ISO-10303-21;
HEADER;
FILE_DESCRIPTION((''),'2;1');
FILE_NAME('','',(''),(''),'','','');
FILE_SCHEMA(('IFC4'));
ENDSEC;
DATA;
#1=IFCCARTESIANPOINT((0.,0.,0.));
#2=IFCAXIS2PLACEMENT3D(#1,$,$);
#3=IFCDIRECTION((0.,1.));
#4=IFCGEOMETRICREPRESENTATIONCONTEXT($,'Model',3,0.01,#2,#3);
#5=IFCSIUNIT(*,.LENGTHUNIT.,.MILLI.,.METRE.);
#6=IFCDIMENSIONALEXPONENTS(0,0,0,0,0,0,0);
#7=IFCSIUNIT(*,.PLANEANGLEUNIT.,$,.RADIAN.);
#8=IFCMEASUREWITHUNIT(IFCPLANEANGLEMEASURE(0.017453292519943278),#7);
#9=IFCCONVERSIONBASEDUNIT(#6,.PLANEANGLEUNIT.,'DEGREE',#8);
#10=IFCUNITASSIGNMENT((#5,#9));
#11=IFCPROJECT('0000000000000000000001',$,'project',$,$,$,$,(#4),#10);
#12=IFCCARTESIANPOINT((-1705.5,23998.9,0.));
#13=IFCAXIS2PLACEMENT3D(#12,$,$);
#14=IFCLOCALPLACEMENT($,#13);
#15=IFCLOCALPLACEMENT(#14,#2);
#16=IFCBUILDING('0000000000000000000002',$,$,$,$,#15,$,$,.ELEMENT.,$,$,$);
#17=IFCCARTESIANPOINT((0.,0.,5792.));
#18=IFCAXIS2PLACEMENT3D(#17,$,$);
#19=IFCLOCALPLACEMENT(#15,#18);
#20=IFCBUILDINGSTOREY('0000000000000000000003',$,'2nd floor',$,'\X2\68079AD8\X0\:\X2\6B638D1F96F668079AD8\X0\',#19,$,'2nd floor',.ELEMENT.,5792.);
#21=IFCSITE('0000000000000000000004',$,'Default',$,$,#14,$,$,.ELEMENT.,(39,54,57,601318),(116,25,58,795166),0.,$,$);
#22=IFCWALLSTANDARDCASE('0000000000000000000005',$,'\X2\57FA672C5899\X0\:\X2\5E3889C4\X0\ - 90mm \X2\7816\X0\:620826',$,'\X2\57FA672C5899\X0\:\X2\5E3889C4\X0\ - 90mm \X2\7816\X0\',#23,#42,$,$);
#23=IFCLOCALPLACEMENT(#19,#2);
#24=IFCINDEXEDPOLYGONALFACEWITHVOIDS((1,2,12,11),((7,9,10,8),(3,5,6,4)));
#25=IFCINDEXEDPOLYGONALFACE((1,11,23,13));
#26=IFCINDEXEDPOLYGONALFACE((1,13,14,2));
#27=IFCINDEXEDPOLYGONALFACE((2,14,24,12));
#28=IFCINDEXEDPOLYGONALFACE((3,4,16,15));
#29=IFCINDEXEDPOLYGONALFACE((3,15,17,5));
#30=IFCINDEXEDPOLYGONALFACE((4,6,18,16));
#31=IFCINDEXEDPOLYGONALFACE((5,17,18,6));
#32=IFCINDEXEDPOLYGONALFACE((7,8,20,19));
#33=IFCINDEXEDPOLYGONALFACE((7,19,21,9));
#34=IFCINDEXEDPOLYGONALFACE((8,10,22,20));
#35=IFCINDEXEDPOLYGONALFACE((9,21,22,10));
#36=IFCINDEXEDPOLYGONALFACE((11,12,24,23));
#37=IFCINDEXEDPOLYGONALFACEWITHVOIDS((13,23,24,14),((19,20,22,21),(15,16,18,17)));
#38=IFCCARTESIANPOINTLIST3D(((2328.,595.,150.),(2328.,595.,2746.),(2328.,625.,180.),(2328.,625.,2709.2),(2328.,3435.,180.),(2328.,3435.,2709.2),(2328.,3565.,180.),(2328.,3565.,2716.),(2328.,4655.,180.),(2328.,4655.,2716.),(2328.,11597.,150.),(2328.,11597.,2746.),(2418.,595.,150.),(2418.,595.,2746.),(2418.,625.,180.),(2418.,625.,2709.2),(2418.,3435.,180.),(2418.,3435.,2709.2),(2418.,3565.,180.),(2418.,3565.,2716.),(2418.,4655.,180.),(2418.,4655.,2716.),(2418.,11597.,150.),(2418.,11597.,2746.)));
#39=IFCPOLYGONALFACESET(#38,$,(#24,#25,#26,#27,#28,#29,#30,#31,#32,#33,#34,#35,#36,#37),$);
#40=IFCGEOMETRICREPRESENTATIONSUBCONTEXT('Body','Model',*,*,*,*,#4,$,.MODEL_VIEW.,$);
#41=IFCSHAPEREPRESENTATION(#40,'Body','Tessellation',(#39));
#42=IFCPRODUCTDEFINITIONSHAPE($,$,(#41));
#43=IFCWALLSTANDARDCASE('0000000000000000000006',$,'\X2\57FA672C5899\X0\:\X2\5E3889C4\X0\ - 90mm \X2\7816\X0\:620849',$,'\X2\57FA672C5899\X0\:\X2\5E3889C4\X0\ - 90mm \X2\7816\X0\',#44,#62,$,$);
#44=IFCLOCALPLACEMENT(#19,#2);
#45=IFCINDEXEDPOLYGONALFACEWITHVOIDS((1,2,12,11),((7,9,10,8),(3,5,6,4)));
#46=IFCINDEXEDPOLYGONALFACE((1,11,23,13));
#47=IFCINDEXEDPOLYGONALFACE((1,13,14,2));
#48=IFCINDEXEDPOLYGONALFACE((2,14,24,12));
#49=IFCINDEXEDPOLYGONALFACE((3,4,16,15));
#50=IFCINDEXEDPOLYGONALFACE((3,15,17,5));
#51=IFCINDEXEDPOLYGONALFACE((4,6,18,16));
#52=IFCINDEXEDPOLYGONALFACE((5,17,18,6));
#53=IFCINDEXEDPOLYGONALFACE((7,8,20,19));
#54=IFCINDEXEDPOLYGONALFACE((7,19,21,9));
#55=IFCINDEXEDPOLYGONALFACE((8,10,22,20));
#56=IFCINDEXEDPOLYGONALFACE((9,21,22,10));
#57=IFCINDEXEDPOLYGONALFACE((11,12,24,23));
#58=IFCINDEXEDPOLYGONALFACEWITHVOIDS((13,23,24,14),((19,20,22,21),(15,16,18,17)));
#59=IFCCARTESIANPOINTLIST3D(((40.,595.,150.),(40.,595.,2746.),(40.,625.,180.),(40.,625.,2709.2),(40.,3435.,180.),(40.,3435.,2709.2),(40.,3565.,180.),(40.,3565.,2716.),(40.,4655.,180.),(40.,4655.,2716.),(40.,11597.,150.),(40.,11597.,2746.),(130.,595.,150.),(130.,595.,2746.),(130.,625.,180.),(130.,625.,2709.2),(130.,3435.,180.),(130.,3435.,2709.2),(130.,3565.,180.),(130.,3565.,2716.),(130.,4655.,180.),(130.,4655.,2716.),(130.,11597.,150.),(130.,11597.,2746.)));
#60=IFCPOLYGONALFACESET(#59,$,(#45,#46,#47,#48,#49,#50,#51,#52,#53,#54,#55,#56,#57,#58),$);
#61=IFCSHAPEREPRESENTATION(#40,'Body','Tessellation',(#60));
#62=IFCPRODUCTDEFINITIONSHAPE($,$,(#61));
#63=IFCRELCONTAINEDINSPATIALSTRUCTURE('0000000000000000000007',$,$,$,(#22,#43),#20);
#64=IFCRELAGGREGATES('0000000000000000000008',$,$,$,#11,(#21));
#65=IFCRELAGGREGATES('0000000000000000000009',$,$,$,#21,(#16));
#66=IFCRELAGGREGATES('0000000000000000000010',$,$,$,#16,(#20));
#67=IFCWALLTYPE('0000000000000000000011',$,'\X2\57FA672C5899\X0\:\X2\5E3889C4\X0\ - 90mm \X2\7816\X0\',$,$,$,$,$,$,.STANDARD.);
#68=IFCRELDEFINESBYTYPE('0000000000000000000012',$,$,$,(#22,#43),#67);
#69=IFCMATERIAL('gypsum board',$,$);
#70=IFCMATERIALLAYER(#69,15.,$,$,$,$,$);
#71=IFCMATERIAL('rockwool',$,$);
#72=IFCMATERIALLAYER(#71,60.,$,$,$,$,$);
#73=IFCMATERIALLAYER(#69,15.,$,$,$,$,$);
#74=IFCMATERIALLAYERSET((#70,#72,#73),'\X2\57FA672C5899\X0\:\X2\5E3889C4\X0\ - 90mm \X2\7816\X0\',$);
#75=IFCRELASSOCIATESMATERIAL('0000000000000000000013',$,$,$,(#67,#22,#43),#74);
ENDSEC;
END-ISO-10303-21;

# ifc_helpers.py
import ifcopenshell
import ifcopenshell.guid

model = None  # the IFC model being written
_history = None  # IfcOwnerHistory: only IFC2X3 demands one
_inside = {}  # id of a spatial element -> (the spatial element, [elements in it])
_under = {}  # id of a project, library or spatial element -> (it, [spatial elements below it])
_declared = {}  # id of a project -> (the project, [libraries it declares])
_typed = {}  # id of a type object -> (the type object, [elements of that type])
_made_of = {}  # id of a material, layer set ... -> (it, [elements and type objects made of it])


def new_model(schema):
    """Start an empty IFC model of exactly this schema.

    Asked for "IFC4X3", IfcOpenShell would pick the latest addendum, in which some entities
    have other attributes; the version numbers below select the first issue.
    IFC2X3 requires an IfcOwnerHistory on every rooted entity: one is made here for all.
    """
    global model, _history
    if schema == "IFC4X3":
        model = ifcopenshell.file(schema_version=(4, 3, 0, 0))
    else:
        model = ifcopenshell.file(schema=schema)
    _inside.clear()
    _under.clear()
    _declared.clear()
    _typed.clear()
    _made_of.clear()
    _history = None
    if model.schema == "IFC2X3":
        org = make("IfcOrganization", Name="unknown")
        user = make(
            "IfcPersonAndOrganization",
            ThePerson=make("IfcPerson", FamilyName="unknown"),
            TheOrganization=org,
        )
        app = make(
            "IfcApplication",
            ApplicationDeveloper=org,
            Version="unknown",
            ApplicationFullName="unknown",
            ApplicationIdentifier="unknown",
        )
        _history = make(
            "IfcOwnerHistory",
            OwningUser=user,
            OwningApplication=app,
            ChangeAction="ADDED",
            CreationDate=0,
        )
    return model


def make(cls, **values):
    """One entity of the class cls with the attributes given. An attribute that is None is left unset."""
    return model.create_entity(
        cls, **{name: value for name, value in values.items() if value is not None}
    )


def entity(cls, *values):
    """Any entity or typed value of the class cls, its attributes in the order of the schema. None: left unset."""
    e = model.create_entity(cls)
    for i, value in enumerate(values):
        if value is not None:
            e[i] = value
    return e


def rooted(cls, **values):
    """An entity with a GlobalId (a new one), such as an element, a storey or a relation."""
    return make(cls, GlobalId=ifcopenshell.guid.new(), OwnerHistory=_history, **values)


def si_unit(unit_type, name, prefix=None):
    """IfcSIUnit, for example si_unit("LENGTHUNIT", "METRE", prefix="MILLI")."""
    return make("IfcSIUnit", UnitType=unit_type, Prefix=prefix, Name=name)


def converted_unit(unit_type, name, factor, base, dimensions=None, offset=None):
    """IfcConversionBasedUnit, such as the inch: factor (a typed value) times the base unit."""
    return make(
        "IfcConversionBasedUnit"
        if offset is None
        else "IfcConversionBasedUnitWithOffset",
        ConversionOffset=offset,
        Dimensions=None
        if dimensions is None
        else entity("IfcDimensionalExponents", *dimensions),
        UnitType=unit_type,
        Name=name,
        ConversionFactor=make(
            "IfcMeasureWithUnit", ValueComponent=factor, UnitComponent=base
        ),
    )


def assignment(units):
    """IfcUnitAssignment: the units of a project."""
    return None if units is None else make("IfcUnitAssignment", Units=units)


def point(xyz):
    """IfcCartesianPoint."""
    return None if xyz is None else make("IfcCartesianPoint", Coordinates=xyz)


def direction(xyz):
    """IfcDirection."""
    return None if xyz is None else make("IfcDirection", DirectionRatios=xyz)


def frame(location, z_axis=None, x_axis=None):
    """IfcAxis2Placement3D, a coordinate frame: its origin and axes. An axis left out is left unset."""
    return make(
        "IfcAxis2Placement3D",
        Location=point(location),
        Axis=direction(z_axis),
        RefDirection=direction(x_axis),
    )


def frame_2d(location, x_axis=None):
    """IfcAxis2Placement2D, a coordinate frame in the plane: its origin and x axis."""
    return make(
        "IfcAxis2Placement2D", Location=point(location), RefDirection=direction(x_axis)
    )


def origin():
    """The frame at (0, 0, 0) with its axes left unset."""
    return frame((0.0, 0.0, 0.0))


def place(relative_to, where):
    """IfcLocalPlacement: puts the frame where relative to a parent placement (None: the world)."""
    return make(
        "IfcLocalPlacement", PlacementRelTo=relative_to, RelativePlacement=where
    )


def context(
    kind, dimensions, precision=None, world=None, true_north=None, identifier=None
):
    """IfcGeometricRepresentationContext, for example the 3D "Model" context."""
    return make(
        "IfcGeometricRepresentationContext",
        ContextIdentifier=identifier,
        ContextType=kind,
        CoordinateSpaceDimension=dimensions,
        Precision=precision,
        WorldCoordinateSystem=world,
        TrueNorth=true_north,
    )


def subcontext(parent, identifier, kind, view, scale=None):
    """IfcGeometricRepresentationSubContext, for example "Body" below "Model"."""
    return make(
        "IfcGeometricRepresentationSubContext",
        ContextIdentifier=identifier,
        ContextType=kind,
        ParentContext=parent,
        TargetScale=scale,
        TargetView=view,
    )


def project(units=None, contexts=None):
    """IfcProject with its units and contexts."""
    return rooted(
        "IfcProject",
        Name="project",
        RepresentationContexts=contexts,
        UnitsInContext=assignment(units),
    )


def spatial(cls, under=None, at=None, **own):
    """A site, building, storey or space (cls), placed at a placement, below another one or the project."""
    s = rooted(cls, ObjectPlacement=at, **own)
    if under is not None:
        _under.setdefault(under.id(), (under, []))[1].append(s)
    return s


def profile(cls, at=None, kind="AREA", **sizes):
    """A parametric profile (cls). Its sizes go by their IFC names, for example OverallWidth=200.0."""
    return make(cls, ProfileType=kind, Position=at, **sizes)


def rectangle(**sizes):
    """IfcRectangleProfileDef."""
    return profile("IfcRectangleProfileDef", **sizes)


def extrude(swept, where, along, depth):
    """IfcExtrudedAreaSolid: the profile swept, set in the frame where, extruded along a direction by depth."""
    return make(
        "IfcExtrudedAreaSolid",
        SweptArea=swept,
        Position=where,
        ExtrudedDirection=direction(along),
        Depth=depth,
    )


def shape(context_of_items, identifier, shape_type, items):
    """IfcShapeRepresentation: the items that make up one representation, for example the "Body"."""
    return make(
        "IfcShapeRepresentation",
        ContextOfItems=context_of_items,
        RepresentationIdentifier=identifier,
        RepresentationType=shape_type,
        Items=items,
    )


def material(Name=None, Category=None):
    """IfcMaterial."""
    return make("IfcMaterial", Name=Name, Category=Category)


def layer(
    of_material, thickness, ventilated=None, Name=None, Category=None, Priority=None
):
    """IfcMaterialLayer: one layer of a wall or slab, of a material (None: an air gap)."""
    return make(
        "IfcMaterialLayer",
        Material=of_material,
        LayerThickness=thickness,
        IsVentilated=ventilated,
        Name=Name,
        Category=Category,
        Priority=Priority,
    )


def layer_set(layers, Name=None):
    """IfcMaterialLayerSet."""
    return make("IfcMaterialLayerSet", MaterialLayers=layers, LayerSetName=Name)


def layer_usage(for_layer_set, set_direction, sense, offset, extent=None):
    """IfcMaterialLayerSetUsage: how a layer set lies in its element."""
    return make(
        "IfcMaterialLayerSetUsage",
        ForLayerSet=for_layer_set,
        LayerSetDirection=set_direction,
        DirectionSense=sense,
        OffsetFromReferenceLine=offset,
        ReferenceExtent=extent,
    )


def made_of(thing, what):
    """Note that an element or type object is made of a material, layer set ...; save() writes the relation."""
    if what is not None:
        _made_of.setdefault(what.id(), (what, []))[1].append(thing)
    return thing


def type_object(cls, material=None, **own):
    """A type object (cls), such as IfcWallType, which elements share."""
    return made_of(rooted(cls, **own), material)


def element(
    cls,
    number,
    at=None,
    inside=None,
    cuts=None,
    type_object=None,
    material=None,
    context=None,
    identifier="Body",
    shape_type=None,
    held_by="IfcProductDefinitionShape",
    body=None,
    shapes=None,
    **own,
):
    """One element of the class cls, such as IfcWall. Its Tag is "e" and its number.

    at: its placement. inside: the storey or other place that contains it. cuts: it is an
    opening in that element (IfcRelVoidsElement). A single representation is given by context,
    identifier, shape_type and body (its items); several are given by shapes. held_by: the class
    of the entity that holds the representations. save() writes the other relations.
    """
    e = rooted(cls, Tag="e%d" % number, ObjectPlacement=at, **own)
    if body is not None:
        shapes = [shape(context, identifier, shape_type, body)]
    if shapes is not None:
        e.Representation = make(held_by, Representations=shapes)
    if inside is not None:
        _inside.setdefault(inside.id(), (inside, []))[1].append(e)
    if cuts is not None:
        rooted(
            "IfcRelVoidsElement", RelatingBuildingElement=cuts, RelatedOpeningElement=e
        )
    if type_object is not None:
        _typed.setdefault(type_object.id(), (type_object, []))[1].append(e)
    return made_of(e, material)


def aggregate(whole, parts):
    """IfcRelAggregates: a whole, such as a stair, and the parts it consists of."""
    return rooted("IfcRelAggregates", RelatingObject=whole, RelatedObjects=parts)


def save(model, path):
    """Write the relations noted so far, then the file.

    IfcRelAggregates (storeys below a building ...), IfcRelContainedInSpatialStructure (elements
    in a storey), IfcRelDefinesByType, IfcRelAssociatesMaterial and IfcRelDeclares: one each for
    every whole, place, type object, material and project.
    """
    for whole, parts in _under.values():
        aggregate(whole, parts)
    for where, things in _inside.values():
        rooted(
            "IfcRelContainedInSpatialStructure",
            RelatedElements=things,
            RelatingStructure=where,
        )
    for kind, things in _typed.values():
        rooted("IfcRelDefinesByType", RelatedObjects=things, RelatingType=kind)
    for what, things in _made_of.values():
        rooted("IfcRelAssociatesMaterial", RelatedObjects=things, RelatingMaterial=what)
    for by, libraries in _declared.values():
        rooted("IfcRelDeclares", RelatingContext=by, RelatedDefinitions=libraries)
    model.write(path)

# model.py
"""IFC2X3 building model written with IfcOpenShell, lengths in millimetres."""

from ifc_helpers import new_model, entity, si_unit, converted_unit, direction, frame, frame_2d, origin, place, context, subcontext, project, spatial, rectangle, extrude, material, layer, layer_set, layer_usage, type_object, element, save


model = new_model("IFC2X3")

# Units and contexts
model_context = context("Model", 3, precision=0.01, world=origin(), true_north=direction((0.0, 1.0)))
body_context = subcontext(model_context, "Body", "Model", "MODEL_VIEW")
ifc_project = project(units=[si_unit("LENGTHUNIT", "METRE", prefix="MILLI"), converted_unit("PLANEANGLEUNIT", "DEGREE", entity("IfcPlaneAngleMeasure", 0.017453292519943278), si_unit("PLANEANGLEUNIT", "RADIAN"), dimensions=[0, 0, 0, 0, 0, 0, 0])], contexts=[model_context])

# Site, building, storey
site_placement = place(None, frame((-1705.5, 23998.9, 0.0)))
site = spatial("IfcSite", under=ifc_project, at=site_placement, Name="Default", CompositionType="ELEMENT", RefLatitude=(39, 54, 57, 601318), RefLongitude=(116, 25, 58, 795166), RefElevation=0.0)
building_placement = place(site_placement, origin())
building = spatial("IfcBuilding", under=site, at=building_placement, CompositionType="ELEMENT")
storey_placement = place(building_placement, frame((0.0, 0.0, 5792.0)))
storey = spatial("IfcBuildingStorey", under=building, at=storey_placement, Name="2nd floor", ObjectType="标高:正负零标高", LongName="2nd floor", CompositionType="ELEMENT", Elevation=5792.0)

# Shared definitions
ifc_material_1 = material(Name="gypsum board")
ifc_layer_1 = layer(ifc_material_1, 15.0)
ifc_material_2 = material(Name="rockwool")
ifc_layer_2 = layer(ifc_material_2, 60.0)
ifc_layer_3 = layer(ifc_material_1, 15.0)
ifc_layer_set = layer_set([ifc_layer_1, ifc_layer_2, ifc_layer_3], Name="基本墙:常规 - 90mm 砖")
wall_type = type_object("IfcWallType", Name="基本墙:常规 - 90mm 砖", PredefinedType="STANDARD", material=ifc_layer_set)

# Walls, openings
ifc_layer_usage_1 = layer_usage(ifc_layer_set, "AXIS2", "NEGATIVE", 45.0)
wall_1_placement = place(storey_placement, frame((2373.0, 11597.0, 150.0), z_axis=(0.0, 0.0, 1.0), x_axis=(0.0, -1.0, 0.0)))
wall_1 = element("IfcWallStandardCase", 1, at=wall_1_placement, inside=storey, type_object=wall_type, material=ifc_layer_usage_1, Name="基本墙:常规 - 90mm 砖:620826", ObjectType="基本墙:常规 - 90mm 砖", context=body_context, shape_type="SweptSolid", body=[
    extrude(rectangle(XDim=11002.0, YDim=90.0, at=frame_2d((5501.0, 0.0), x_axis=(-1.0, 0.0))), origin(), (0.0, 0.0, 1.0), 2596.0),
])
opening_1_placement = place(wall_1_placement, origin())
element("IfcOpeningElement", 2, at=opening_1_placement, cuts=wall_1, ObjectType="Opening", context=body_context, shape_type="SweptSolid", body=[
    extrude(rectangle(XDim=2536.0, YDim=1090.0, at=frame_2d((0.0, 0.0), x_axis=(0.0, 1.0))), frame((7487.0, 45.0, 1298.0), z_axis=(0.0, -1.0, 0.0), x_axis=(-1.0, 0.0, 0.0)), (0.0, 0.0, 1.0), 90.0),
])
opening_2_placement = place(wall_1_placement, origin())
element("IfcOpeningElement", 3, at=opening_2_placement, cuts=wall_1, ObjectType="Opening", context=body_context, shape_type="SweptSolid", body=[
    extrude(rectangle(XDim=2529.2, YDim=2810.0, at=frame_2d((0.0, 0.0), x_axis=(0.0, 1.0))), frame((9567.0, 45.0, 1294.6), z_axis=(0.0, -1.0, 0.0), x_axis=(-1.0, 0.0, 0.0)), (0.0, 0.0, 1.0), 90.0),
])
ifc_layer_usage_2 = layer_usage(ifc_layer_set, "AXIS2", "NEGATIVE", 45.0)
wall_2_placement = place(storey_placement, frame((85.0, 11597.0, 150.0), z_axis=(0.0, 0.0, 1.0), x_axis=(0.0, -1.0, 0.0)))
wall_2 = element("IfcWallStandardCase", 4, at=wall_2_placement, inside=storey, type_object=wall_type, material=ifc_layer_usage_2, Name="基本墙:常规 - 90mm 砖:620849", ObjectType="基本墙:常规 - 90mm 砖", context=body_context, shape_type="SweptSolid", body=[
    extrude(rectangle(XDim=11002.0, YDim=90.0, at=frame_2d((5501.0, 0.0), x_axis=(-1.0, 0.0))), origin(), (0.0, 0.0, 1.0), 2596.0),
])
opening_3_placement = place(wall_2_placement, origin())
element("IfcOpeningElement", 5, at=opening_3_placement, cuts=wall_2, ObjectType="Opening", context=body_context, shape_type="SweptSolid", body=[
    extrude(rectangle(XDim=2536.0, YDim=1090.0, at=frame_2d((0.0, 0.0), x_axis=(0.0, 1.0))), frame((7487.0, 45.0, 1298.0), z_axis=(0.0, -1.0, 0.0), x_axis=(-1.0, 0.0, 0.0)), (0.0, 0.0, 1.0), 90.0),
])
opening_4_placement = place(wall_2_placement, origin())
element("IfcOpeningElement", 6, at=opening_4_placement, cuts=wall_2, ObjectType="Opening", context=body_context, shape_type="SweptSolid", body=[
    extrude(rectangle(XDim=2529.2, YDim=2810.0, at=frame_2d((0.0, 0.0), x_axis=(0.0, 1.0))), frame((9567.0, 45.0, 1294.6), z_axis=(0.0, -1.0, 0.0), x_axis=(-1.0, 0.0, 0.0)), (0.0, 0.0, 1.0), 90.0),
])

save(model, "model.ifc")
